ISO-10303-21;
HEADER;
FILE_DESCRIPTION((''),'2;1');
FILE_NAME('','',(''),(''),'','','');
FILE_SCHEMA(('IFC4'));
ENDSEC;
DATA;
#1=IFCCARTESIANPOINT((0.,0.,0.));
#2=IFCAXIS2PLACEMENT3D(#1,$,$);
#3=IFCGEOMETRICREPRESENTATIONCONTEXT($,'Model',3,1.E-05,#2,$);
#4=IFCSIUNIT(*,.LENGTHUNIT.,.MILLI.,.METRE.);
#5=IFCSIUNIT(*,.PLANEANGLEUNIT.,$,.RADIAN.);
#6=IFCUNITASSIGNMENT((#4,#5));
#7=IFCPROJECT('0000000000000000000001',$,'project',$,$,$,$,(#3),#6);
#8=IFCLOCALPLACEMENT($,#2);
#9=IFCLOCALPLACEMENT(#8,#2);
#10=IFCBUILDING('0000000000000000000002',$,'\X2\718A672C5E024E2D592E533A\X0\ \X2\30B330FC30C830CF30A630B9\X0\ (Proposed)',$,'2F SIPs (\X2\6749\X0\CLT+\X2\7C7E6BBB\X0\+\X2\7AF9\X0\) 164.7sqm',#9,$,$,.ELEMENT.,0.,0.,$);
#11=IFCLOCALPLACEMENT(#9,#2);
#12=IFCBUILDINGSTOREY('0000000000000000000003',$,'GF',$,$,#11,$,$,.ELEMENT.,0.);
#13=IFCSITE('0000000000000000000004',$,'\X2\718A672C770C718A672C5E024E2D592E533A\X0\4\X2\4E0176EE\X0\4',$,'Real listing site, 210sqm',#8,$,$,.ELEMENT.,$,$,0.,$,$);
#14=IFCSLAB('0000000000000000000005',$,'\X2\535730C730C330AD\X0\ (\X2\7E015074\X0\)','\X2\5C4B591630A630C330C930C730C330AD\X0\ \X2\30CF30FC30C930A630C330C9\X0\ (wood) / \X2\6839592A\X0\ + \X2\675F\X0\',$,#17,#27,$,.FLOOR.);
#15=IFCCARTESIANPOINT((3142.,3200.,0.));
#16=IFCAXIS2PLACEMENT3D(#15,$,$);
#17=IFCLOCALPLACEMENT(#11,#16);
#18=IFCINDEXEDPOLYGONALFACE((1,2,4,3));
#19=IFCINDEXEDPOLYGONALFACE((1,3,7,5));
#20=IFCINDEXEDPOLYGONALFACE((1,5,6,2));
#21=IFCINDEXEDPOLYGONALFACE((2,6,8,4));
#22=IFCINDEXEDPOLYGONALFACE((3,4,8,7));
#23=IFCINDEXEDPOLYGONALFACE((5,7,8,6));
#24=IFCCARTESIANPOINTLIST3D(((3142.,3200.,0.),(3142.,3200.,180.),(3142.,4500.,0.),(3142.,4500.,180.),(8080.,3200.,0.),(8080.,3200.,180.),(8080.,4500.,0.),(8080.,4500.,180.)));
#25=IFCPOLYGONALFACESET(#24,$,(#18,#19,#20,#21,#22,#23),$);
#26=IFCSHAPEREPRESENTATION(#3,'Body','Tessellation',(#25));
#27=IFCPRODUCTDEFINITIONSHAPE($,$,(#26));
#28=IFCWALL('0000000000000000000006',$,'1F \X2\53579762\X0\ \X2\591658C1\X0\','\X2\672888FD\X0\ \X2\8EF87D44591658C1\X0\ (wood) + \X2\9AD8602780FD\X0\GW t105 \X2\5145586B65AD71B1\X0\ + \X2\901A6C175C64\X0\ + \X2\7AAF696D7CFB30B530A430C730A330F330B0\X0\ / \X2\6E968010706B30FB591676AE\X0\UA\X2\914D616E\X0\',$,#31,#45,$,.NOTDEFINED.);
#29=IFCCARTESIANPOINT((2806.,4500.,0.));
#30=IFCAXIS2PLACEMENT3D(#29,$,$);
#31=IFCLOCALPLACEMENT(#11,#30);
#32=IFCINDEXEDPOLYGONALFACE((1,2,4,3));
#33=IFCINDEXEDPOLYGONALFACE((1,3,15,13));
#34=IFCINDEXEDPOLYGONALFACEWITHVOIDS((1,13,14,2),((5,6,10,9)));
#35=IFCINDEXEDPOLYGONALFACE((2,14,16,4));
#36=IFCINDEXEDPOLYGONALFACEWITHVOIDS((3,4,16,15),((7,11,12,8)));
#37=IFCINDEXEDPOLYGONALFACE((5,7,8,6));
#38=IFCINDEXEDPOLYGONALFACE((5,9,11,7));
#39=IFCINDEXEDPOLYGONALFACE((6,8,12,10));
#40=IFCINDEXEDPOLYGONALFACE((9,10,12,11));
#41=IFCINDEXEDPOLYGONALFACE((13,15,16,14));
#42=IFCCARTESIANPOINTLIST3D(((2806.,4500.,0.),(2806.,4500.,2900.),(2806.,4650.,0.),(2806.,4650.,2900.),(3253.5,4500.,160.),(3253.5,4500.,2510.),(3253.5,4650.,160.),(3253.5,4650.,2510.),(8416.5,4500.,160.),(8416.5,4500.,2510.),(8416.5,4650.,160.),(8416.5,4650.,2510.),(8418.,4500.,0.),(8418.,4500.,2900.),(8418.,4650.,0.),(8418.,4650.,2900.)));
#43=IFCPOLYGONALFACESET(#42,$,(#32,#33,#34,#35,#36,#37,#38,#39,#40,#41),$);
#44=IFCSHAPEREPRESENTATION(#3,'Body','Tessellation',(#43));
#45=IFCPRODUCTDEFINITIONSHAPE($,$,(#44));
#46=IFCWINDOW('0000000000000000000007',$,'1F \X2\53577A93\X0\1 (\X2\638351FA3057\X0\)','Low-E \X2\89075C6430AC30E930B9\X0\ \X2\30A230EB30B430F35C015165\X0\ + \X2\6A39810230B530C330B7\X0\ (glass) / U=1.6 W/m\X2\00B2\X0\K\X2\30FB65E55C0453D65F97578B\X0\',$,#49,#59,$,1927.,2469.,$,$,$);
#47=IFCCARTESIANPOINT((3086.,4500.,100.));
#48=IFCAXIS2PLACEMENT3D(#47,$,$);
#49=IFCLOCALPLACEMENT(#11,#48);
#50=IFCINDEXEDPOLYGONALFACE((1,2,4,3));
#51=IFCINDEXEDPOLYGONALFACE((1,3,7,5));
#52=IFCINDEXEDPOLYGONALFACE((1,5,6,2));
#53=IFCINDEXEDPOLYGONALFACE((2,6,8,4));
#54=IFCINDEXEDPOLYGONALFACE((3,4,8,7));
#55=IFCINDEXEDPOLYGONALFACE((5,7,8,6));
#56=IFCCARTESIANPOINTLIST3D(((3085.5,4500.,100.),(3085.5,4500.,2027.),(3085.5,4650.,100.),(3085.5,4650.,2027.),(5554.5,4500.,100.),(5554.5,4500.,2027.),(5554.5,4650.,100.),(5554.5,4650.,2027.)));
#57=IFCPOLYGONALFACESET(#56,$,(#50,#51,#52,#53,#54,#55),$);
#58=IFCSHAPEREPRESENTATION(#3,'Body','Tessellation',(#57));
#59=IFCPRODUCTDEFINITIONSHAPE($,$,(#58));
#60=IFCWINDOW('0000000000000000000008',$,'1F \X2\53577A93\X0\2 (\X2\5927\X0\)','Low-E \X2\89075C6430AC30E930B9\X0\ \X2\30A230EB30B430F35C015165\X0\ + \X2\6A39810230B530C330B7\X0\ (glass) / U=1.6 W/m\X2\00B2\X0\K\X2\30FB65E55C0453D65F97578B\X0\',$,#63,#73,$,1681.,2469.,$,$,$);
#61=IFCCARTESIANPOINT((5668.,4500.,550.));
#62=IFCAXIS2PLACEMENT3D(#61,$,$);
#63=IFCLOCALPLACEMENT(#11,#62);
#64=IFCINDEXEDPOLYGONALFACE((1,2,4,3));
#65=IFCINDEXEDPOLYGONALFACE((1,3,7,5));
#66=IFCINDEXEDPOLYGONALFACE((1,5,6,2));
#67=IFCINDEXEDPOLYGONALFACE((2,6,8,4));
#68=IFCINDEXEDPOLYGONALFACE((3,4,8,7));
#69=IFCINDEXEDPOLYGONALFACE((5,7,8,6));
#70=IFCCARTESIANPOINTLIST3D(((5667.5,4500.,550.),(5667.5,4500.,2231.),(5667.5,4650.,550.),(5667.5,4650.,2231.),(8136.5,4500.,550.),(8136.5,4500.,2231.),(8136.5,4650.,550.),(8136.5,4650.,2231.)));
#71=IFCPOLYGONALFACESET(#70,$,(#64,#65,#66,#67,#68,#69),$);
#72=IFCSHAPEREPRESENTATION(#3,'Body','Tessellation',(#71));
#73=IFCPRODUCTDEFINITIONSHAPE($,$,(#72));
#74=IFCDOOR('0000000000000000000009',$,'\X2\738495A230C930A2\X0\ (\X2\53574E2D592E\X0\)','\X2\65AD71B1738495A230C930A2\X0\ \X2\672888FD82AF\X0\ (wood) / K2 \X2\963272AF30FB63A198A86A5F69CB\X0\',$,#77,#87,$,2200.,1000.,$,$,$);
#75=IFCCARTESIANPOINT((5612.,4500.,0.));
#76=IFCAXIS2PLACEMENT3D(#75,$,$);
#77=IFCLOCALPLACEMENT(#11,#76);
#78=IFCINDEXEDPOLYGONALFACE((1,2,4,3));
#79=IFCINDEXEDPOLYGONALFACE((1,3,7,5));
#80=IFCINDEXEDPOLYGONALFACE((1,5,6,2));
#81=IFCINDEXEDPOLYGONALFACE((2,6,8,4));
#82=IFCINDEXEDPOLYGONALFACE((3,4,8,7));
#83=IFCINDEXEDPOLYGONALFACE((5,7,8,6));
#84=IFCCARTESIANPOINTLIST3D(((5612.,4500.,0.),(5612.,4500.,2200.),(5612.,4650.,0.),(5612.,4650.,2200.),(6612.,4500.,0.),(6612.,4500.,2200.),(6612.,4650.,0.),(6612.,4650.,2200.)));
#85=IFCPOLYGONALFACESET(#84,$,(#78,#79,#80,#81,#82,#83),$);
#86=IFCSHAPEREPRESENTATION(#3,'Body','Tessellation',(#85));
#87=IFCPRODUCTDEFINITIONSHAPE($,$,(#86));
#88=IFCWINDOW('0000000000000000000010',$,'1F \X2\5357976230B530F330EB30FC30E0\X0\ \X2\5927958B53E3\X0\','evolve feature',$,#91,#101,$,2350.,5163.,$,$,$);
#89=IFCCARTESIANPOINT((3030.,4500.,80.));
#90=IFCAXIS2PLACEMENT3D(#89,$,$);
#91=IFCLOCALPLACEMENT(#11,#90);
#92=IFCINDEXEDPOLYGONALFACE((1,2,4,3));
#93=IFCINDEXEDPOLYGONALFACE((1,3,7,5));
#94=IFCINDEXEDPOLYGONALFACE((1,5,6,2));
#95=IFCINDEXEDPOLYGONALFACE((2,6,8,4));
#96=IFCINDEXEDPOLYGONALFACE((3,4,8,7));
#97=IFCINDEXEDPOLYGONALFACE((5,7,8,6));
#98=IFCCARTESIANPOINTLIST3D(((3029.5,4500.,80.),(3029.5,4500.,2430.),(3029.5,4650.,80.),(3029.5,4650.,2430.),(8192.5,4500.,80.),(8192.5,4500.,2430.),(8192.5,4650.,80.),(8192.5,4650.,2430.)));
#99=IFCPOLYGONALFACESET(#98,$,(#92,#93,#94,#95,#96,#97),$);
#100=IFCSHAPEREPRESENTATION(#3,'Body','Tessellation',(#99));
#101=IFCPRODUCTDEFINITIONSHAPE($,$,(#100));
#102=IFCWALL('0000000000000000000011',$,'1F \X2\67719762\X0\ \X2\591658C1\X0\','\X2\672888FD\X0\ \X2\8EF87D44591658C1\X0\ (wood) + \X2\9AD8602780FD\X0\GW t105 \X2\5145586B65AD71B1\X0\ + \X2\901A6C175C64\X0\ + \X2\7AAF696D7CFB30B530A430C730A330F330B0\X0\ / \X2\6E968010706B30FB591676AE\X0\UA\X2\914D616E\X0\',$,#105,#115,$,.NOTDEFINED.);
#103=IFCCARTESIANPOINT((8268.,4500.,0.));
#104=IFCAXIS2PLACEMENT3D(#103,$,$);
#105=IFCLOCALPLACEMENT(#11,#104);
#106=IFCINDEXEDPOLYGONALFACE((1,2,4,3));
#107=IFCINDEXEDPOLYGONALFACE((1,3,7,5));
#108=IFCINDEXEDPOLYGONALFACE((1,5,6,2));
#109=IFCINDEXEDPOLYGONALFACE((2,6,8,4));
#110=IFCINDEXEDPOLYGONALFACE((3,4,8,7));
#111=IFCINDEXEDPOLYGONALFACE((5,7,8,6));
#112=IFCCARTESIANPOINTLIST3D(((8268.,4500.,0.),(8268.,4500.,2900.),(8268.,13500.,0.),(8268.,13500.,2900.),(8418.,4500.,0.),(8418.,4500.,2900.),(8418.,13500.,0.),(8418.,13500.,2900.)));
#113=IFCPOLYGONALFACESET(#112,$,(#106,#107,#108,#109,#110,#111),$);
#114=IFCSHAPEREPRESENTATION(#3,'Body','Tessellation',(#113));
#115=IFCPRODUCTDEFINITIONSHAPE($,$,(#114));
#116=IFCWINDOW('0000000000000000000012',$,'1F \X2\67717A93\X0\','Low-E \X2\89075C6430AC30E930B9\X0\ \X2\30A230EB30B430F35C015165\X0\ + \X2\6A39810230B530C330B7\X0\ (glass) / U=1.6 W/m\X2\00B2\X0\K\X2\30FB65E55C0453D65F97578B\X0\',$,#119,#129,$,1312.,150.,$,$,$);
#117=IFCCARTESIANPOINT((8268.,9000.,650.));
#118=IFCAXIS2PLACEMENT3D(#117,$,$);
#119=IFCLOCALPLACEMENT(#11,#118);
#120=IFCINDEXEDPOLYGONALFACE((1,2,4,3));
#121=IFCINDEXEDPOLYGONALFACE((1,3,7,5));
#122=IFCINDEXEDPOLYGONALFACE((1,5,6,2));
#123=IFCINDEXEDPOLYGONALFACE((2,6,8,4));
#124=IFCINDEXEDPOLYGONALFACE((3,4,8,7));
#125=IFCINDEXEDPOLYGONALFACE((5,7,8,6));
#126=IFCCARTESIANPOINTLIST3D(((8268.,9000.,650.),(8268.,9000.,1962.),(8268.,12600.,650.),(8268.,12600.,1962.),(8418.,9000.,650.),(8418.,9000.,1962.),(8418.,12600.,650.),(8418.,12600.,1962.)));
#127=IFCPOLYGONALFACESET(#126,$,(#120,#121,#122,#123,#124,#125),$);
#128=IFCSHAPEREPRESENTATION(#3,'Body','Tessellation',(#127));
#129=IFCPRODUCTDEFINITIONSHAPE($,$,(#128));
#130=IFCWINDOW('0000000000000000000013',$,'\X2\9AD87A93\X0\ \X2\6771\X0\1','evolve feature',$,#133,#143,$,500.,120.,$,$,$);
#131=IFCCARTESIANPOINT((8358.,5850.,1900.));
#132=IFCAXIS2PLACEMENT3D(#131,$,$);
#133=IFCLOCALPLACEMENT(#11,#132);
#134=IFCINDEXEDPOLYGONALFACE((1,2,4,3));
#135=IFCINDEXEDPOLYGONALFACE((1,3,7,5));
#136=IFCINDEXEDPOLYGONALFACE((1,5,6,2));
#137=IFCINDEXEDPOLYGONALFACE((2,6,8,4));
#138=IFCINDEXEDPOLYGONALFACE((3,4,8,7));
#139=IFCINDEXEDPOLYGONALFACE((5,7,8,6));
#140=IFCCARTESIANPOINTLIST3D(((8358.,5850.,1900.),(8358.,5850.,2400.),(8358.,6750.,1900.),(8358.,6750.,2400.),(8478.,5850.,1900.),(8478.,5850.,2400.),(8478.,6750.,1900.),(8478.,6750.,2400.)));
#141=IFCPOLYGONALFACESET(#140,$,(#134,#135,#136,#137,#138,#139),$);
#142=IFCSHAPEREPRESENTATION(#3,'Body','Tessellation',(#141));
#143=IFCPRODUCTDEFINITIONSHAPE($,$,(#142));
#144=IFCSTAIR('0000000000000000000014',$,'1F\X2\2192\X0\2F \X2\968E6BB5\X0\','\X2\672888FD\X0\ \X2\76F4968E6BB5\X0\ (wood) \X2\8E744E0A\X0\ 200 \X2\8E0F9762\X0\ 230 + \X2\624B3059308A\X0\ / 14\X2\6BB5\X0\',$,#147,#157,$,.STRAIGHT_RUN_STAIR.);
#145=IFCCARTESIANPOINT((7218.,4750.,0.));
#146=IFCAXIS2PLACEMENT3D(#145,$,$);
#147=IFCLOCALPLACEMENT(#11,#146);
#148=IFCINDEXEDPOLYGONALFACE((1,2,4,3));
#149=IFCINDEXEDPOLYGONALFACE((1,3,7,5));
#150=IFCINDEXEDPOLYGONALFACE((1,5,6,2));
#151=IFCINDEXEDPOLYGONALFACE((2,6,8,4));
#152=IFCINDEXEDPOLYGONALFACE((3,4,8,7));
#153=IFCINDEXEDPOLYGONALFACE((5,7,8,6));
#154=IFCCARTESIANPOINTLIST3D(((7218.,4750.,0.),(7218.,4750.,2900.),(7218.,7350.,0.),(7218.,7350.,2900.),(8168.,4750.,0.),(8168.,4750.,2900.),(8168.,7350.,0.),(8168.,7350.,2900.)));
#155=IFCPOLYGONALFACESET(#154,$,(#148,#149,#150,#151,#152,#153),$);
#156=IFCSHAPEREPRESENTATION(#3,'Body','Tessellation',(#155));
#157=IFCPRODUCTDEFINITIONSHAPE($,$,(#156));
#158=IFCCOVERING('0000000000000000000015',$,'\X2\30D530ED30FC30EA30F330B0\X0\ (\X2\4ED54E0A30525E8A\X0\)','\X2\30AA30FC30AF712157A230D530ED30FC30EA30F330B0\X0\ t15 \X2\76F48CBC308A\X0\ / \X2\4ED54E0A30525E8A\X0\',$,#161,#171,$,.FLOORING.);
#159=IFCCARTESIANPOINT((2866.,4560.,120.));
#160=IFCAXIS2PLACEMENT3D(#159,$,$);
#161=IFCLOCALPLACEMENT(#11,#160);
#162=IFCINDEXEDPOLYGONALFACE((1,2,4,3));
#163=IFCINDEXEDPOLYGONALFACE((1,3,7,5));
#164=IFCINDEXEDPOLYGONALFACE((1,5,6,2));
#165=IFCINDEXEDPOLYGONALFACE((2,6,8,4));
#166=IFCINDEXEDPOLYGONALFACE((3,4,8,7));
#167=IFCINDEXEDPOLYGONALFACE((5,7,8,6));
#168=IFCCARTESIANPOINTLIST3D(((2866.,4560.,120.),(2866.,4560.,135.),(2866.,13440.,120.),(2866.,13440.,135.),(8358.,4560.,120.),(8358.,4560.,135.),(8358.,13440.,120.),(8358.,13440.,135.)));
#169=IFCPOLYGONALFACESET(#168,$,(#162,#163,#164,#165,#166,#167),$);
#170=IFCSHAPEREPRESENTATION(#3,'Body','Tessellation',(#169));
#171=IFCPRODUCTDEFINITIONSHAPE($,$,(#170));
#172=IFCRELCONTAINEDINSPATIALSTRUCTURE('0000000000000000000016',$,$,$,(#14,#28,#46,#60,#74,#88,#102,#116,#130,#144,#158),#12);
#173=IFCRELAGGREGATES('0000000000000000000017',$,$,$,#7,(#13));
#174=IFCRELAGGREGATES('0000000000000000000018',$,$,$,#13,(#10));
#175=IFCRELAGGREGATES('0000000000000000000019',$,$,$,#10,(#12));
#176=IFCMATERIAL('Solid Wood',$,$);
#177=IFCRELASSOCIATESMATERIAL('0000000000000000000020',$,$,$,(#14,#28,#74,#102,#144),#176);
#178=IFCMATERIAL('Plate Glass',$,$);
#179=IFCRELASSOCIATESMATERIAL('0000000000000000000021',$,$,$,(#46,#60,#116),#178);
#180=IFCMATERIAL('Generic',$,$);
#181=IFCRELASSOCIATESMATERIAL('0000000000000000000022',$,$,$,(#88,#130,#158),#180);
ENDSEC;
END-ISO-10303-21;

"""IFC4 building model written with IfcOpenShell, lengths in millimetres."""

from ifc_helpers import new_model, si_unit, frame, frame_2d, origin, place, context, project, spatial, rectangle, extrude, material, element, fill, save


model = new_model("IFC4")

# Units and contexts
model_context = context("Model", 3, precision=1e-05, world=origin())
ifc_project = project(units=[si_unit("LENGTHUNIT", "METRE", prefix="MILLI"), si_unit("PLANEANGLEUNIT", "RADIAN")], contexts=[model_context])

# Site, building, storey
site_placement = place(None, origin())
site = spatial("IfcSite", under=ifc_project, at=site_placement, Name="熊本県熊本市中央区4丁目4", ObjectType="Real listing site, 210sqm", CompositionType="ELEMENT", RefElevation=0.0)
building_placement = place(site_placement, origin())
building = spatial("IfcBuilding", under=site, at=building_placement, Name="熊本市中央区 コートハウス (Proposed)", ObjectType="2F SIPs (杉CLT+籾殻+竹) 164.7sqm", CompositionType="ELEMENT", ElevationOfRefHeight=0.0, ElevationOfTerrain=0.0)
storey_placement = place(building_placement, origin())
storey = spatial("IfcBuildingStorey", under=building, at=storey_placement, Name="GF", CompositionType="ELEMENT", Elevation=0.0)

# Slab
ifc_material_1 = material(Name="Solid Wood")
slab_1_placement = place(storey_placement, frame((3142.0, 3200.0, 0.0)))
element("IfcSlab", 1, at=slab_1_placement, inside=storey, material=ifc_material_1, Name="南デッキ (縁側)", Description="屋外ウッドデッキ ハードウッド (wood) / 根太 + 束", PredefinedType="FLOOR", context=model_context, shape_type="SweptSolid", body=[
    extrude(rectangle(XDim=4938.0, YDim=1300.0, at=frame_2d((2469.0, 650.0))), frame((3142.0, 3200.0, 0.0)), (0.0, 0.0, 1.0), 180.0),
])
ifc_material_2 = material(Name="Generic")

# Wall, openings, windows, door
wall_1_placement = place(storey_placement, frame((2806.0, 4500.0, 0.0)))
wall_1 = element("IfcWall", 2, at=wall_1_placement, inside=storey, material=ifc_material_1, Name="1F 南面 外壁", Description="木製 軸組外壁 (wood) + 高性能GW t105 充填断熱 + 通気層 + 窯業系サイディング / 準耐火・外皮UA配慮", PredefinedType="NOTDEFINED", context=model_context, shape_type="SweptSolid", body=[
    extrude(rectangle(XDim=5612.0, YDim=150.0, at=frame_2d((2806.0, 75.0))), frame((2806.0, 4500.0, 0.0)), (0.0, 0.0, 1.0), 2900.0),
])
opening_1_placement = place(storey_placement, frame((3086.0, 4500.0, 100.0)))
opening_1 = element("IfcOpeningElement", 3, at=opening_1_placement, cuts=wall_1, PredefinedType="NOTDEFINED", context=model_context, shape_type="SweptSolid", body=[
    extrude(rectangle(XDim=2469.0, YDim=150.0, at=frame_2d((1234.0, 75.0))), frame((3086.0, 4500.0, 100.0)), (0.0, 0.0, 1.0), 1927.0),
])
opening_2_placement = place(storey_placement, frame((5668.0, 4500.0, 550.0)))
opening_2 = element("IfcOpeningElement", 4, at=opening_2_placement, cuts=wall_1, PredefinedType="NOTDEFINED", context=model_context, shape_type="SweptSolid", body=[
    extrude(rectangle(XDim=2469.0, YDim=150.0, at=frame_2d((1234.0, 75.0))), frame((5668.0, 4500.0, 550.0)), (0.0, 0.0, 1.0), 1681.0),
])
opening_3_placement = place(storey_placement, frame((5612.0, 4500.0, 0.0)))
opening_3 = element("IfcOpeningElement", 5, at=opening_3_placement, cuts=wall_1, PredefinedType="NOTDEFINED", context=model_context, shape_type="SweptSolid", body=[
    extrude(rectangle(XDim=1000.0, YDim=150.0, at=frame_2d((500.0, 75.0))), frame((5612.0, 4500.0, 0.0)), (0.0, 0.0, 1.0), 2200.0),
])
opening_4_placement = place(storey_placement, frame((3030.0, 4500.0, 80.0)))
opening_4 = element("IfcOpeningElement", 6, at=opening_4_placement, cuts=wall_1, PredefinedType="NOTDEFINED", context=model_context, shape_type="SweptSolid", body=[
    extrude(rectangle(XDim=5163.0, YDim=150.0, at=frame_2d((2581.0, 75.0))), frame((3030.0, 4500.0, 80.0)), (0.0, 0.0, 1.0), 2350.0),
])
ifc_material_3 = material(Name="Plate Glass")
window_1_placement = place(storey_placement, frame((3086.0, 4500.0, 100.0)))
window_1 = element("IfcWindow", 7, at=window_1_placement, inside=storey, material=ifc_material_3, Name="1F 南窓1 (掃出し)", Description="Low-E 複層ガラス アルゴン封入 + 樹脂サッシ (glass) / U=1.6 W/m²K・日射取得型", OverallHeight=1927.0, OverallWidth=2469.0, context=model_context, shape_type="SweptSolid", body=[
    extrude(rectangle(XDim=2469.0, YDim=150.0, at=frame_2d((1234.0, 75.0))), frame((3086.0, 4500.0, 100.0)), (0.0, 0.0, 1.0), 1927.0),
])
fill(opening_1, window_1)
window_2_placement = place(storey_placement, frame((5668.0, 4500.0, 550.0)))
window_2 = element("IfcWindow", 8, at=window_2_placement, inside=storey, material=ifc_material_3, Name="1F 南窓2 (大)", Description="Low-E 複層ガラス アルゴン封入 + 樹脂サッシ (glass) / U=1.6 W/m²K・日射取得型", OverallHeight=1681.0, OverallWidth=2469.0, context=model_context, shape_type="SweptSolid", body=[
    extrude(rectangle(XDim=2469.0, YDim=150.0, at=frame_2d((1234.0, 75.0))), frame((5668.0, 4500.0, 550.0)), (0.0, 0.0, 1.0), 1681.0),
])
fill(opening_2, window_2)
door_placement = place(storey_placement, frame((5612.0, 4500.0, 0.0)))
door = element("IfcDoor", 9, at=door_placement, inside=storey, material=ifc_material_1, Name="玄関ドア (南中央)", Description="断熱玄関ドア 木製芯 (wood) / K2 防犯・採風機構", OverallHeight=2200.0, OverallWidth=1000.0, context=model_context, shape_type="SweptSolid", body=[
    extrude(rectangle(XDim=1000.0, YDim=150.0, at=frame_2d((500.0, 75.0))), frame((5612.0, 4500.0, 0.0)), (0.0, 0.0, 1.0), 2200.0),
])
fill(opening_3, door)
window_3_placement = place(storey_placement, frame((3030.0, 4500.0, 80.0)))
window_3 = element("IfcWindow", 10, at=window_3_placement, inside=storey, material=ifc_material_2, Name="1F 南面サンルーム 大開口", Description="evolve feature", OverallHeight=2350.0, OverallWidth=5163.0, context=model_context, shape_type="SweptSolid", body=[
    extrude(rectangle(XDim=5163.0, YDim=150.0, at=frame_2d((2581.0, 75.0))), frame((3030.0, 4500.0, 80.0)), (0.0, 0.0, 1.0), 2350.0),
])
fill(opening_4, window_3)

# Wall, openings, windows
wall_2_placement = place(storey_placement, frame((8268.0, 4500.0, 0.0)))
wall_2 = element("IfcWall", 11, at=wall_2_placement, inside=storey, material=ifc_material_1, Name="1F 東面 外壁", Description="木製 軸組外壁 (wood) + 高性能GW t105 充填断熱 + 通気層 + 窯業系サイディング / 準耐火・外皮UA配慮", PredefinedType="NOTDEFINED", context=model_context, shape_type="SweptSolid", body=[
    extrude(rectangle(XDim=150.0, YDim=9000.0, at=frame_2d((75.0, 4500.0))), frame((8268.0, 4500.0, 0.0)), (0.0, 0.0, 1.0), 2900.0),
])
opening_5_placement = place(storey_placement, frame((8268.0, 9000.0, 650.0)))
opening_5 = element("IfcOpeningElement", 12, at=opening_5_placement, cuts=wall_2, PredefinedType="NOTDEFINED", context=model_context, shape_type="SweptSolid", body=[
    extrude(rectangle(XDim=150.0, YDim=3600.0, at=frame_2d((75.0, 1800.0))), frame((8268.0, 9000.0, 650.0)), (0.0, 0.0, 1.0), 1312.0),
])
opening_6_placement = place(storey_placement, frame((8358.0, 5850.0, 1900.0)))
opening_6 = element("IfcOpeningElement", 13, at=opening_6_placement, cuts=wall_2, PredefinedType="NOTDEFINED", context=model_context, shape_type="SweptSolid", body=[
    extrude(rectangle(XDim=120.0, YDim=900.0, at=frame_2d((60.0, 450.0))), frame((8358.0, 5850.0, 1900.0)), (0.0, 0.0, 1.0), 500.0),
])
window_4_placement = place(storey_placement, frame((8268.0, 9000.0, 650.0)))
window_4 = element("IfcWindow", 14, at=window_4_placement, inside=storey, material=ifc_material_3, Name="1F 東窓", Description="Low-E 複層ガラス アルゴン封入 + 樹脂サッシ (glass) / U=1.6 W/m²K・日射取得型", OverallHeight=1312.0, OverallWidth=150.0, context=model_context, shape_type="SweptSolid", body=[
    extrude(rectangle(XDim=150.0, YDim=3600.0, at=frame_2d((75.0, 1800.0))), frame((8268.0, 9000.0, 650.0)), (0.0, 0.0, 1.0), 1312.0),
])
fill(opening_5, window_4)
window_5_placement = place(storey_placement, frame((8358.0, 5850.0, 1900.0)))
window_5 = element("IfcWindow", 15, at=window_5_placement, inside=storey, material=ifc_material_2, Name="高窓 東1", Description="evolve feature", OverallHeight=500.0, OverallWidth=120.0, context=model_context, shape_type="SweptSolid", body=[
    extrude(rectangle(XDim=120.0, YDim=900.0, at=frame_2d((60.0, 450.0))), frame((8358.0, 5850.0, 1900.0)), (0.0, 0.0, 1.0), 500.0),
])
fill(opening_6, window_5)

# Stair
stair_placement = place(storey_placement, frame((7218.0, 4750.0, 0.0)))
element("IfcStair", 16, at=stair_placement, inside=storey, material=ifc_material_1, Name="1F→2F 階段", Description="木製 直階段 (wood) 蹴上 200 踏面 230 + 手すり / 14段", PredefinedType="STRAIGHT_RUN_STAIR", context=model_context, shape_type="SweptSolid", body=[
    extrude(rectangle(XDim=950.0, YDim=2600.0, at=frame_2d((475.0, 1300.0))), frame((7218.0, 4750.0, 0.0)), (0.0, 0.0, 1.0), 2900.0),
])

# Covering
covering_placement = place(storey_placement, frame((2866.0, 4560.0, 120.0)))
element("IfcCovering", 17, at=covering_placement, inside=storey, material=ifc_material_2, Name="フローリング (仕上げ床)", Description="オーク無垢フローリング t15 直貼り / 仕上げ床", PredefinedType="FLOORING", context=model_context, shape_type="SweptSolid", body=[
    extrude(rectangle(XDim=5492.0, YDim=8880.0, at=frame_2d((2746.0, 4440.0))), frame((2866.0, 4560.0, 120.0)), (0.0, 0.0, 1.0), 15.0),
])

save(model, "model.ifc")
